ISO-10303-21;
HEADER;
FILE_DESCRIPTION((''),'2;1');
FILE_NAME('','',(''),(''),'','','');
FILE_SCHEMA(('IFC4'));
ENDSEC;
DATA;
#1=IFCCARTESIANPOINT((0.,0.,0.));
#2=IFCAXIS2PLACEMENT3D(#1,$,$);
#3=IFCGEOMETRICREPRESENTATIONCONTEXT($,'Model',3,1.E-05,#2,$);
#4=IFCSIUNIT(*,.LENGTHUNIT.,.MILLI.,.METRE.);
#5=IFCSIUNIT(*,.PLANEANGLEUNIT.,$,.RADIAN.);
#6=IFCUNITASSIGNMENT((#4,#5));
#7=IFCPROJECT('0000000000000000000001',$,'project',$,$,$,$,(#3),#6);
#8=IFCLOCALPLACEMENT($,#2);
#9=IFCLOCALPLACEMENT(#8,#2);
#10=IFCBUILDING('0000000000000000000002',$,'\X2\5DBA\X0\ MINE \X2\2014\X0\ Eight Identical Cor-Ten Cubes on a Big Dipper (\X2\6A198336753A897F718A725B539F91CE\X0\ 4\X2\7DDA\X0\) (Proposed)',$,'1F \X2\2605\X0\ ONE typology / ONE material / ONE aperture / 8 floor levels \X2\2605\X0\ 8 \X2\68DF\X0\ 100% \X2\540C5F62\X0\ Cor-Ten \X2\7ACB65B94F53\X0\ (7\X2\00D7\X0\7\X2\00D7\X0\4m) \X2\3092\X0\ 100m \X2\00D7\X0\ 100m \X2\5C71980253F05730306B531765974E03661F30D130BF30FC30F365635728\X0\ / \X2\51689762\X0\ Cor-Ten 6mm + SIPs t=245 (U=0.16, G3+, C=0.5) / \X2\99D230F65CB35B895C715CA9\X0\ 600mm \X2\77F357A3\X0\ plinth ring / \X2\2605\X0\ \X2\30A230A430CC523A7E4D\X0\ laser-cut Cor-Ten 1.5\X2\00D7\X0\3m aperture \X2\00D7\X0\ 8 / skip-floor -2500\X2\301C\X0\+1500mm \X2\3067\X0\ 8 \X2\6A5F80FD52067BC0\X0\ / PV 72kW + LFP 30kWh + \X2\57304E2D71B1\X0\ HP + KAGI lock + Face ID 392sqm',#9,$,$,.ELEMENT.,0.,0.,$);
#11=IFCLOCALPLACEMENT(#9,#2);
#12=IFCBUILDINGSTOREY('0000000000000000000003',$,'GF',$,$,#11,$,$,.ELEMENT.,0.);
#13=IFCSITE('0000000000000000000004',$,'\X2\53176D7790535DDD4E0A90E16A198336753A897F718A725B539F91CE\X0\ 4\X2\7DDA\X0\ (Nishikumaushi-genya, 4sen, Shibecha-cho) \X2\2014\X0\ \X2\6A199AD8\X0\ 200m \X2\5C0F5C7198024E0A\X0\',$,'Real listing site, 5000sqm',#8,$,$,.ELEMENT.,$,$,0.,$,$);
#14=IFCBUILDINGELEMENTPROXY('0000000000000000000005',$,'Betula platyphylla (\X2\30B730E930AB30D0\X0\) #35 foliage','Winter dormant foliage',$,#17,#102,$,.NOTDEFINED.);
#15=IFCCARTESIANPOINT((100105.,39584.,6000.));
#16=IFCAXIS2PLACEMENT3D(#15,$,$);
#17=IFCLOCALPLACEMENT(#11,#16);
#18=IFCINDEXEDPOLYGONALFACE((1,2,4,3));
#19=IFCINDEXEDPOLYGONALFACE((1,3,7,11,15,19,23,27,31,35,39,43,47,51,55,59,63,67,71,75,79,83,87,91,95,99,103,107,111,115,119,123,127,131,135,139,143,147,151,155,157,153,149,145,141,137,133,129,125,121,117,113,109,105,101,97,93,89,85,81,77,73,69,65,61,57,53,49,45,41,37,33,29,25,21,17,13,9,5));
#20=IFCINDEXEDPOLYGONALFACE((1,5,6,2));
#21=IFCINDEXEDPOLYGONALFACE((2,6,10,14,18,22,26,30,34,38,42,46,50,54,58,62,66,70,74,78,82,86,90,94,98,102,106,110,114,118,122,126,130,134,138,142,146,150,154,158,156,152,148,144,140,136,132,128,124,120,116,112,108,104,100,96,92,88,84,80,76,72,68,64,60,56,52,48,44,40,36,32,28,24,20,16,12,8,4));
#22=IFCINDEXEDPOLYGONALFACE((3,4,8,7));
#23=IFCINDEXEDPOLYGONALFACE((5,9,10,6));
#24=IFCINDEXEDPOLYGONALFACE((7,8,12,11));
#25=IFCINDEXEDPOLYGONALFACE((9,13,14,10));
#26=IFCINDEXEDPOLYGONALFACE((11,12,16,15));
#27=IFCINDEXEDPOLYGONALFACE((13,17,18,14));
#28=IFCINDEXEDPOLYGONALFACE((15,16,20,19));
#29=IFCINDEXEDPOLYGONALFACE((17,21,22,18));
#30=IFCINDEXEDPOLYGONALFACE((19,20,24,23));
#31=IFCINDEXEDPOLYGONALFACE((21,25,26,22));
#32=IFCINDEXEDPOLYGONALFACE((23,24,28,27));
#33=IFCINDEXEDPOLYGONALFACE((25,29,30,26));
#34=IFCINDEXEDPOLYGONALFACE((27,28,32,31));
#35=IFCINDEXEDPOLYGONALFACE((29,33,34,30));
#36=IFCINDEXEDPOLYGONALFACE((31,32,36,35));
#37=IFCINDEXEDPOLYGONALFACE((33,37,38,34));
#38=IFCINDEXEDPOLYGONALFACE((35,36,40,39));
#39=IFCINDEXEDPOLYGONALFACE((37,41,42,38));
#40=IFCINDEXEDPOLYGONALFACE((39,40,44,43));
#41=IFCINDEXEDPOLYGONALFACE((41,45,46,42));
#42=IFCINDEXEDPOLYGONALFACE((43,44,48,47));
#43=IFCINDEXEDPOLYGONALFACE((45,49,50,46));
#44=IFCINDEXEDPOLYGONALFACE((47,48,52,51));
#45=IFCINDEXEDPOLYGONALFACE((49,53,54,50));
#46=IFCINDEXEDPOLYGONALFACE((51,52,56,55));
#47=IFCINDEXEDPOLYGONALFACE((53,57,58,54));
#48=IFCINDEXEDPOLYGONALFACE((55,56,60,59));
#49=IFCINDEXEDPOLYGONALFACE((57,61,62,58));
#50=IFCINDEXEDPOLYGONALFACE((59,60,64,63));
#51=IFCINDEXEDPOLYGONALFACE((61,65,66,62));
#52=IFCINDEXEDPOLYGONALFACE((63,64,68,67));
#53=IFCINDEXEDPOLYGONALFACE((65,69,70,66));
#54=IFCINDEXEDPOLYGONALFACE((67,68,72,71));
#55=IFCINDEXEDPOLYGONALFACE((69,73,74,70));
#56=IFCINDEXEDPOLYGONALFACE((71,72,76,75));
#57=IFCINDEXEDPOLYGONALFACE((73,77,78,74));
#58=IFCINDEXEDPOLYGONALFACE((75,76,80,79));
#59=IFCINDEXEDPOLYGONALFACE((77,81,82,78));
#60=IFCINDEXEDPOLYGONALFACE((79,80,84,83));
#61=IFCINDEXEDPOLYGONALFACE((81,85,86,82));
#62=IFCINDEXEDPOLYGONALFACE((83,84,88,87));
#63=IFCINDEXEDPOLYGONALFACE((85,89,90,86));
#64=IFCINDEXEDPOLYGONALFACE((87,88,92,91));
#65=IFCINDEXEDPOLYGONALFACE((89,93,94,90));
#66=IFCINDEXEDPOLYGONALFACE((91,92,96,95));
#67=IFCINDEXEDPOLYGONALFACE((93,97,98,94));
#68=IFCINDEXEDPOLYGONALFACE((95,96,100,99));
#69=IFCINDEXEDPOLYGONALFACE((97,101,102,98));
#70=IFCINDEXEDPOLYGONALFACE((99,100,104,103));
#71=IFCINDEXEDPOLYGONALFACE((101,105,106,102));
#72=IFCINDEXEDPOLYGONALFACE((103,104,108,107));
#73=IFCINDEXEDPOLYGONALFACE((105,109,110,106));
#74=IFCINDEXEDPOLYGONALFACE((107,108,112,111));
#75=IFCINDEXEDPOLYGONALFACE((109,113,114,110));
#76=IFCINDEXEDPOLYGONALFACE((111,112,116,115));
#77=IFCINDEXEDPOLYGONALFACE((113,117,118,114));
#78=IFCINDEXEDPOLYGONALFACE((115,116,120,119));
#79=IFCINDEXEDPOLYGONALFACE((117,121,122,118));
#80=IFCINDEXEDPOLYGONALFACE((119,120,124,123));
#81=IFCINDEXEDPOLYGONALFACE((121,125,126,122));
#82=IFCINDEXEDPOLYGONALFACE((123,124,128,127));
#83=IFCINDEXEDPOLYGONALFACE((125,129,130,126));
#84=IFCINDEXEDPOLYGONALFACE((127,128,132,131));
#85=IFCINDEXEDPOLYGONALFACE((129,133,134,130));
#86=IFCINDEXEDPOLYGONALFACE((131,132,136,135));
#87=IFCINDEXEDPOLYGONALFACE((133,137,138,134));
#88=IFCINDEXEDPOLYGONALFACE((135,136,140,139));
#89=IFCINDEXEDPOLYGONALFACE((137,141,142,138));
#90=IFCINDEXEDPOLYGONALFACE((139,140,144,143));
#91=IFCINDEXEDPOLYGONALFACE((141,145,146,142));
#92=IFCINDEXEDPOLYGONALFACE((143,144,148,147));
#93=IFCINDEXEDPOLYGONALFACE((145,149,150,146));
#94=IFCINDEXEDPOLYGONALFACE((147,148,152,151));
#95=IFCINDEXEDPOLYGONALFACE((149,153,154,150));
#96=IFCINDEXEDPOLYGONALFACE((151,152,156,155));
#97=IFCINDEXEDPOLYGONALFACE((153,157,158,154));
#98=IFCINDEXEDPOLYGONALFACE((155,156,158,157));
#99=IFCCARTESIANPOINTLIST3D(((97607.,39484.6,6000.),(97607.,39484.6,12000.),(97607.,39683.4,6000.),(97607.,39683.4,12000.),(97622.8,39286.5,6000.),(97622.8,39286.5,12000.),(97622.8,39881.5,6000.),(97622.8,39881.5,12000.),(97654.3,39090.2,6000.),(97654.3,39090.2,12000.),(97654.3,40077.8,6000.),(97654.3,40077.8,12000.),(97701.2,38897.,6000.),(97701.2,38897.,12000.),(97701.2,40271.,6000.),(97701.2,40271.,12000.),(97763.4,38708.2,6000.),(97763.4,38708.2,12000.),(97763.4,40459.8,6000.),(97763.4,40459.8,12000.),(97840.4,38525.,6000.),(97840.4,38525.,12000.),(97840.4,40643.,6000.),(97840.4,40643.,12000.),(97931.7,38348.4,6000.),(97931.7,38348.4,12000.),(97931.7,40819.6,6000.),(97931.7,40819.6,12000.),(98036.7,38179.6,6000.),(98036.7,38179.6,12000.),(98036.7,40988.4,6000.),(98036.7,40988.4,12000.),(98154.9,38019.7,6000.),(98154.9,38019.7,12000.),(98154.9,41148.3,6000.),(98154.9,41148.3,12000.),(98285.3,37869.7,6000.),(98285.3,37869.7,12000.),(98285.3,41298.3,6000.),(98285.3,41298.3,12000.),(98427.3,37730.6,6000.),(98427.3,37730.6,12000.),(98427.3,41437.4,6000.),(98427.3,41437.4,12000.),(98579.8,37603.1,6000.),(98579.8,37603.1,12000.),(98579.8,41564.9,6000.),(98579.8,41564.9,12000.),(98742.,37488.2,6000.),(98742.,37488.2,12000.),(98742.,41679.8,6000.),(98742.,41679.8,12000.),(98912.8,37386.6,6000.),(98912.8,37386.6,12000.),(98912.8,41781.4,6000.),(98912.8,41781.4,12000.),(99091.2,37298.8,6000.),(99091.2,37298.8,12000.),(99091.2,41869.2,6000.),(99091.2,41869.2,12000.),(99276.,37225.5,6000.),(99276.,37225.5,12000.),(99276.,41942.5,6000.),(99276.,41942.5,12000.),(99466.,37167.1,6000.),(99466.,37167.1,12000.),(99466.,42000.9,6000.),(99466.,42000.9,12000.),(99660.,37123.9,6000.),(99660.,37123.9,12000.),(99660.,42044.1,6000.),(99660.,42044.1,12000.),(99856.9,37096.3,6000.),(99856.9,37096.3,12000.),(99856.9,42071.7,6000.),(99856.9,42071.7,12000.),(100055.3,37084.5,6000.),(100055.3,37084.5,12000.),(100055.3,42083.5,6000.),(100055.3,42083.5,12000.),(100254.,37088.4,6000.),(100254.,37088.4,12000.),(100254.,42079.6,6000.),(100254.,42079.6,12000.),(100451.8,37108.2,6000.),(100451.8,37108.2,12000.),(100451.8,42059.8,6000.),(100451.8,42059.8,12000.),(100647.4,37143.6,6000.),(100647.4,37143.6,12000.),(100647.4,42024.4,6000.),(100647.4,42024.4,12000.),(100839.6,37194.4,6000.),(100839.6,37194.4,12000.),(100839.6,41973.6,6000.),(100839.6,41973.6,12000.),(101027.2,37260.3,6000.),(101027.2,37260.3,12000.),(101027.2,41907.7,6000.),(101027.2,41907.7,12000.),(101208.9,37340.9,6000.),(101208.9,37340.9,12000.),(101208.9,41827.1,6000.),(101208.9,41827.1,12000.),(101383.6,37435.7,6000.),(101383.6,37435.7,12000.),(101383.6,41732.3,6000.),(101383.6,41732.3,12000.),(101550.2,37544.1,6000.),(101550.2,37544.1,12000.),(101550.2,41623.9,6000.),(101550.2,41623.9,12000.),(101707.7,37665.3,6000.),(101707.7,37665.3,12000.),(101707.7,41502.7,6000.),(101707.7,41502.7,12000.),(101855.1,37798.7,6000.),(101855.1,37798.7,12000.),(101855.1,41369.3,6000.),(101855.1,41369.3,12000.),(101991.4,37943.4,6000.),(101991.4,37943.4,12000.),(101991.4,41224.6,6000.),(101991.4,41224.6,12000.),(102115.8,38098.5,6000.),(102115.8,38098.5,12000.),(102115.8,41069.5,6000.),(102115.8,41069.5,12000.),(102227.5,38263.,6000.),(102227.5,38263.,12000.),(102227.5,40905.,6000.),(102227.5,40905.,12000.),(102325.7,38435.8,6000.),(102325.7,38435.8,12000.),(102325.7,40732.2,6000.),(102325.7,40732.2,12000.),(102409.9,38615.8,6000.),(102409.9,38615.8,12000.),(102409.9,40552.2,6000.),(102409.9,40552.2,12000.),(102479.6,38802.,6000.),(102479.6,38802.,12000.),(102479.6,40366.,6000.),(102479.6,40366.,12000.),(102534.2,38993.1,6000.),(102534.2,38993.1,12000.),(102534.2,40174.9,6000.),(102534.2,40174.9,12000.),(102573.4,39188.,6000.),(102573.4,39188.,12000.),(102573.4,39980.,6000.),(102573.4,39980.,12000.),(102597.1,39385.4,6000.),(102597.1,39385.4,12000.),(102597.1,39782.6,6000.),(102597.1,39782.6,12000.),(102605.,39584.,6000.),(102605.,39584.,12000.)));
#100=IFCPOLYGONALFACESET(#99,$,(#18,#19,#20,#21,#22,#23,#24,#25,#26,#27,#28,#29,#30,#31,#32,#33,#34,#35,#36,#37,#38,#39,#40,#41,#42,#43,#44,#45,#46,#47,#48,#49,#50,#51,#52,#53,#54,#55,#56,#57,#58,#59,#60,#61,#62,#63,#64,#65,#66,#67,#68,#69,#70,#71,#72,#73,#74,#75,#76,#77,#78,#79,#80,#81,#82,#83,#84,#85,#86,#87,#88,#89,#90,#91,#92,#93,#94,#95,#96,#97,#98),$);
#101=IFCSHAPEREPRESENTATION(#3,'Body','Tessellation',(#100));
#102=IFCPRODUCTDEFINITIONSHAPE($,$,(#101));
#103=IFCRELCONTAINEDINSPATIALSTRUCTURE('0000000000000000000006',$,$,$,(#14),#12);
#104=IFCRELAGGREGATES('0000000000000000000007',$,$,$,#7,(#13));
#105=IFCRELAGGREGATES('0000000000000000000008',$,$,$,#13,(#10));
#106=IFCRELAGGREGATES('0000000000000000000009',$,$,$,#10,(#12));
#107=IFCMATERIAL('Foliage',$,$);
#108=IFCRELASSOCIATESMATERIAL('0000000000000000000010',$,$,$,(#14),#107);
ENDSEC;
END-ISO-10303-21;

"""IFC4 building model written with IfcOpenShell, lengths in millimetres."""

from ifc_helpers import new_model, si_unit, frame, origin, origin_2d, place, context, project, spatial, circle, extrude, material, element, save


model = new_model("IFC4")

# Units and contexts
model_context = context("Model", 3, precision=1e-05, world=origin())
ifc_project = project(units=[si_unit("LENGTHUNIT", "METRE", prefix="MILLI"), si_unit("PLANEANGLEUNIT", "RADIAN")], contexts=[model_context])

# Site, building, storey
site_placement = place(None, origin())
site = spatial("IfcSite", under=ifc_project, at=site_placement, Name="北海道川上郡標茶町西熊牛原野 4線 (Nishikumaushi-genya, 4sen, Shibecha-cho) — 標高 200m 小山頂上", ObjectType="Real listing site, 5000sqm", CompositionType="ELEMENT", RefElevation=0.0)
building_placement = place(site_placement, origin())
building = spatial("IfcBuilding", under=site, at=building_placement, Name="嶺 MINE — Eight Identical Cor-Ten Cubes on a Big Dipper (標茶町西熊牛原野 4線) (Proposed)", ObjectType="1F ★ ONE typology / ONE material / ONE aperture / 8 floor levels ★ 8 棟 100% 同形 Cor-Ten 立方体 (7×7×4m) を 100m × 100m 山頂台地に北斗七星パターン散在 / 全面 Cor-Ten 6mm + SIPs t=245 (U=0.16, G3+, C=0.5) / 駒ヶ岳安山岩 600mm 石垣 plinth ring / ★ アイヌ刺繍 laser-cut Cor-Ten 1.5×3m aperture × 8 / skip-floor -2500〜+1500mm で 8 機能分節 / PV 72kW + LFP 30kWh + 地中熱 HP + KAGI lock + Face ID 392sqm", CompositionType="ELEMENT", ElevationOfRefHeight=0.0, ElevationOfTerrain=0.0)
storey_placement = place(building_placement, origin())
storey = spatial("IfcBuildingStorey", under=building, at=storey_placement, Name="GF", CompositionType="ELEMENT", Elevation=0.0)

# Building element proxy
ifc_material_1 = material(Name="Foliage")
proxy_1_placement = place(storey_placement, frame((100105.0, 39584.0, 6000.0)))
element("IfcBuildingElementProxy", 1, at=proxy_1_placement, inside=storey, material=ifc_material_1, Name="Betula platyphylla (シラカバ) #35 foliage", Description="Winter dormant foliage", PredefinedType="NOTDEFINED", context=model_context, shape_type="SweptSolid", body=[
    extrude(circle(Radius=2500.0, at=origin_2d()), frame((100105.0, 39584.0, 6000.0)), (0.0, 0.0, 1.0), 6000.0),
])

save(model, "model.ifc")
